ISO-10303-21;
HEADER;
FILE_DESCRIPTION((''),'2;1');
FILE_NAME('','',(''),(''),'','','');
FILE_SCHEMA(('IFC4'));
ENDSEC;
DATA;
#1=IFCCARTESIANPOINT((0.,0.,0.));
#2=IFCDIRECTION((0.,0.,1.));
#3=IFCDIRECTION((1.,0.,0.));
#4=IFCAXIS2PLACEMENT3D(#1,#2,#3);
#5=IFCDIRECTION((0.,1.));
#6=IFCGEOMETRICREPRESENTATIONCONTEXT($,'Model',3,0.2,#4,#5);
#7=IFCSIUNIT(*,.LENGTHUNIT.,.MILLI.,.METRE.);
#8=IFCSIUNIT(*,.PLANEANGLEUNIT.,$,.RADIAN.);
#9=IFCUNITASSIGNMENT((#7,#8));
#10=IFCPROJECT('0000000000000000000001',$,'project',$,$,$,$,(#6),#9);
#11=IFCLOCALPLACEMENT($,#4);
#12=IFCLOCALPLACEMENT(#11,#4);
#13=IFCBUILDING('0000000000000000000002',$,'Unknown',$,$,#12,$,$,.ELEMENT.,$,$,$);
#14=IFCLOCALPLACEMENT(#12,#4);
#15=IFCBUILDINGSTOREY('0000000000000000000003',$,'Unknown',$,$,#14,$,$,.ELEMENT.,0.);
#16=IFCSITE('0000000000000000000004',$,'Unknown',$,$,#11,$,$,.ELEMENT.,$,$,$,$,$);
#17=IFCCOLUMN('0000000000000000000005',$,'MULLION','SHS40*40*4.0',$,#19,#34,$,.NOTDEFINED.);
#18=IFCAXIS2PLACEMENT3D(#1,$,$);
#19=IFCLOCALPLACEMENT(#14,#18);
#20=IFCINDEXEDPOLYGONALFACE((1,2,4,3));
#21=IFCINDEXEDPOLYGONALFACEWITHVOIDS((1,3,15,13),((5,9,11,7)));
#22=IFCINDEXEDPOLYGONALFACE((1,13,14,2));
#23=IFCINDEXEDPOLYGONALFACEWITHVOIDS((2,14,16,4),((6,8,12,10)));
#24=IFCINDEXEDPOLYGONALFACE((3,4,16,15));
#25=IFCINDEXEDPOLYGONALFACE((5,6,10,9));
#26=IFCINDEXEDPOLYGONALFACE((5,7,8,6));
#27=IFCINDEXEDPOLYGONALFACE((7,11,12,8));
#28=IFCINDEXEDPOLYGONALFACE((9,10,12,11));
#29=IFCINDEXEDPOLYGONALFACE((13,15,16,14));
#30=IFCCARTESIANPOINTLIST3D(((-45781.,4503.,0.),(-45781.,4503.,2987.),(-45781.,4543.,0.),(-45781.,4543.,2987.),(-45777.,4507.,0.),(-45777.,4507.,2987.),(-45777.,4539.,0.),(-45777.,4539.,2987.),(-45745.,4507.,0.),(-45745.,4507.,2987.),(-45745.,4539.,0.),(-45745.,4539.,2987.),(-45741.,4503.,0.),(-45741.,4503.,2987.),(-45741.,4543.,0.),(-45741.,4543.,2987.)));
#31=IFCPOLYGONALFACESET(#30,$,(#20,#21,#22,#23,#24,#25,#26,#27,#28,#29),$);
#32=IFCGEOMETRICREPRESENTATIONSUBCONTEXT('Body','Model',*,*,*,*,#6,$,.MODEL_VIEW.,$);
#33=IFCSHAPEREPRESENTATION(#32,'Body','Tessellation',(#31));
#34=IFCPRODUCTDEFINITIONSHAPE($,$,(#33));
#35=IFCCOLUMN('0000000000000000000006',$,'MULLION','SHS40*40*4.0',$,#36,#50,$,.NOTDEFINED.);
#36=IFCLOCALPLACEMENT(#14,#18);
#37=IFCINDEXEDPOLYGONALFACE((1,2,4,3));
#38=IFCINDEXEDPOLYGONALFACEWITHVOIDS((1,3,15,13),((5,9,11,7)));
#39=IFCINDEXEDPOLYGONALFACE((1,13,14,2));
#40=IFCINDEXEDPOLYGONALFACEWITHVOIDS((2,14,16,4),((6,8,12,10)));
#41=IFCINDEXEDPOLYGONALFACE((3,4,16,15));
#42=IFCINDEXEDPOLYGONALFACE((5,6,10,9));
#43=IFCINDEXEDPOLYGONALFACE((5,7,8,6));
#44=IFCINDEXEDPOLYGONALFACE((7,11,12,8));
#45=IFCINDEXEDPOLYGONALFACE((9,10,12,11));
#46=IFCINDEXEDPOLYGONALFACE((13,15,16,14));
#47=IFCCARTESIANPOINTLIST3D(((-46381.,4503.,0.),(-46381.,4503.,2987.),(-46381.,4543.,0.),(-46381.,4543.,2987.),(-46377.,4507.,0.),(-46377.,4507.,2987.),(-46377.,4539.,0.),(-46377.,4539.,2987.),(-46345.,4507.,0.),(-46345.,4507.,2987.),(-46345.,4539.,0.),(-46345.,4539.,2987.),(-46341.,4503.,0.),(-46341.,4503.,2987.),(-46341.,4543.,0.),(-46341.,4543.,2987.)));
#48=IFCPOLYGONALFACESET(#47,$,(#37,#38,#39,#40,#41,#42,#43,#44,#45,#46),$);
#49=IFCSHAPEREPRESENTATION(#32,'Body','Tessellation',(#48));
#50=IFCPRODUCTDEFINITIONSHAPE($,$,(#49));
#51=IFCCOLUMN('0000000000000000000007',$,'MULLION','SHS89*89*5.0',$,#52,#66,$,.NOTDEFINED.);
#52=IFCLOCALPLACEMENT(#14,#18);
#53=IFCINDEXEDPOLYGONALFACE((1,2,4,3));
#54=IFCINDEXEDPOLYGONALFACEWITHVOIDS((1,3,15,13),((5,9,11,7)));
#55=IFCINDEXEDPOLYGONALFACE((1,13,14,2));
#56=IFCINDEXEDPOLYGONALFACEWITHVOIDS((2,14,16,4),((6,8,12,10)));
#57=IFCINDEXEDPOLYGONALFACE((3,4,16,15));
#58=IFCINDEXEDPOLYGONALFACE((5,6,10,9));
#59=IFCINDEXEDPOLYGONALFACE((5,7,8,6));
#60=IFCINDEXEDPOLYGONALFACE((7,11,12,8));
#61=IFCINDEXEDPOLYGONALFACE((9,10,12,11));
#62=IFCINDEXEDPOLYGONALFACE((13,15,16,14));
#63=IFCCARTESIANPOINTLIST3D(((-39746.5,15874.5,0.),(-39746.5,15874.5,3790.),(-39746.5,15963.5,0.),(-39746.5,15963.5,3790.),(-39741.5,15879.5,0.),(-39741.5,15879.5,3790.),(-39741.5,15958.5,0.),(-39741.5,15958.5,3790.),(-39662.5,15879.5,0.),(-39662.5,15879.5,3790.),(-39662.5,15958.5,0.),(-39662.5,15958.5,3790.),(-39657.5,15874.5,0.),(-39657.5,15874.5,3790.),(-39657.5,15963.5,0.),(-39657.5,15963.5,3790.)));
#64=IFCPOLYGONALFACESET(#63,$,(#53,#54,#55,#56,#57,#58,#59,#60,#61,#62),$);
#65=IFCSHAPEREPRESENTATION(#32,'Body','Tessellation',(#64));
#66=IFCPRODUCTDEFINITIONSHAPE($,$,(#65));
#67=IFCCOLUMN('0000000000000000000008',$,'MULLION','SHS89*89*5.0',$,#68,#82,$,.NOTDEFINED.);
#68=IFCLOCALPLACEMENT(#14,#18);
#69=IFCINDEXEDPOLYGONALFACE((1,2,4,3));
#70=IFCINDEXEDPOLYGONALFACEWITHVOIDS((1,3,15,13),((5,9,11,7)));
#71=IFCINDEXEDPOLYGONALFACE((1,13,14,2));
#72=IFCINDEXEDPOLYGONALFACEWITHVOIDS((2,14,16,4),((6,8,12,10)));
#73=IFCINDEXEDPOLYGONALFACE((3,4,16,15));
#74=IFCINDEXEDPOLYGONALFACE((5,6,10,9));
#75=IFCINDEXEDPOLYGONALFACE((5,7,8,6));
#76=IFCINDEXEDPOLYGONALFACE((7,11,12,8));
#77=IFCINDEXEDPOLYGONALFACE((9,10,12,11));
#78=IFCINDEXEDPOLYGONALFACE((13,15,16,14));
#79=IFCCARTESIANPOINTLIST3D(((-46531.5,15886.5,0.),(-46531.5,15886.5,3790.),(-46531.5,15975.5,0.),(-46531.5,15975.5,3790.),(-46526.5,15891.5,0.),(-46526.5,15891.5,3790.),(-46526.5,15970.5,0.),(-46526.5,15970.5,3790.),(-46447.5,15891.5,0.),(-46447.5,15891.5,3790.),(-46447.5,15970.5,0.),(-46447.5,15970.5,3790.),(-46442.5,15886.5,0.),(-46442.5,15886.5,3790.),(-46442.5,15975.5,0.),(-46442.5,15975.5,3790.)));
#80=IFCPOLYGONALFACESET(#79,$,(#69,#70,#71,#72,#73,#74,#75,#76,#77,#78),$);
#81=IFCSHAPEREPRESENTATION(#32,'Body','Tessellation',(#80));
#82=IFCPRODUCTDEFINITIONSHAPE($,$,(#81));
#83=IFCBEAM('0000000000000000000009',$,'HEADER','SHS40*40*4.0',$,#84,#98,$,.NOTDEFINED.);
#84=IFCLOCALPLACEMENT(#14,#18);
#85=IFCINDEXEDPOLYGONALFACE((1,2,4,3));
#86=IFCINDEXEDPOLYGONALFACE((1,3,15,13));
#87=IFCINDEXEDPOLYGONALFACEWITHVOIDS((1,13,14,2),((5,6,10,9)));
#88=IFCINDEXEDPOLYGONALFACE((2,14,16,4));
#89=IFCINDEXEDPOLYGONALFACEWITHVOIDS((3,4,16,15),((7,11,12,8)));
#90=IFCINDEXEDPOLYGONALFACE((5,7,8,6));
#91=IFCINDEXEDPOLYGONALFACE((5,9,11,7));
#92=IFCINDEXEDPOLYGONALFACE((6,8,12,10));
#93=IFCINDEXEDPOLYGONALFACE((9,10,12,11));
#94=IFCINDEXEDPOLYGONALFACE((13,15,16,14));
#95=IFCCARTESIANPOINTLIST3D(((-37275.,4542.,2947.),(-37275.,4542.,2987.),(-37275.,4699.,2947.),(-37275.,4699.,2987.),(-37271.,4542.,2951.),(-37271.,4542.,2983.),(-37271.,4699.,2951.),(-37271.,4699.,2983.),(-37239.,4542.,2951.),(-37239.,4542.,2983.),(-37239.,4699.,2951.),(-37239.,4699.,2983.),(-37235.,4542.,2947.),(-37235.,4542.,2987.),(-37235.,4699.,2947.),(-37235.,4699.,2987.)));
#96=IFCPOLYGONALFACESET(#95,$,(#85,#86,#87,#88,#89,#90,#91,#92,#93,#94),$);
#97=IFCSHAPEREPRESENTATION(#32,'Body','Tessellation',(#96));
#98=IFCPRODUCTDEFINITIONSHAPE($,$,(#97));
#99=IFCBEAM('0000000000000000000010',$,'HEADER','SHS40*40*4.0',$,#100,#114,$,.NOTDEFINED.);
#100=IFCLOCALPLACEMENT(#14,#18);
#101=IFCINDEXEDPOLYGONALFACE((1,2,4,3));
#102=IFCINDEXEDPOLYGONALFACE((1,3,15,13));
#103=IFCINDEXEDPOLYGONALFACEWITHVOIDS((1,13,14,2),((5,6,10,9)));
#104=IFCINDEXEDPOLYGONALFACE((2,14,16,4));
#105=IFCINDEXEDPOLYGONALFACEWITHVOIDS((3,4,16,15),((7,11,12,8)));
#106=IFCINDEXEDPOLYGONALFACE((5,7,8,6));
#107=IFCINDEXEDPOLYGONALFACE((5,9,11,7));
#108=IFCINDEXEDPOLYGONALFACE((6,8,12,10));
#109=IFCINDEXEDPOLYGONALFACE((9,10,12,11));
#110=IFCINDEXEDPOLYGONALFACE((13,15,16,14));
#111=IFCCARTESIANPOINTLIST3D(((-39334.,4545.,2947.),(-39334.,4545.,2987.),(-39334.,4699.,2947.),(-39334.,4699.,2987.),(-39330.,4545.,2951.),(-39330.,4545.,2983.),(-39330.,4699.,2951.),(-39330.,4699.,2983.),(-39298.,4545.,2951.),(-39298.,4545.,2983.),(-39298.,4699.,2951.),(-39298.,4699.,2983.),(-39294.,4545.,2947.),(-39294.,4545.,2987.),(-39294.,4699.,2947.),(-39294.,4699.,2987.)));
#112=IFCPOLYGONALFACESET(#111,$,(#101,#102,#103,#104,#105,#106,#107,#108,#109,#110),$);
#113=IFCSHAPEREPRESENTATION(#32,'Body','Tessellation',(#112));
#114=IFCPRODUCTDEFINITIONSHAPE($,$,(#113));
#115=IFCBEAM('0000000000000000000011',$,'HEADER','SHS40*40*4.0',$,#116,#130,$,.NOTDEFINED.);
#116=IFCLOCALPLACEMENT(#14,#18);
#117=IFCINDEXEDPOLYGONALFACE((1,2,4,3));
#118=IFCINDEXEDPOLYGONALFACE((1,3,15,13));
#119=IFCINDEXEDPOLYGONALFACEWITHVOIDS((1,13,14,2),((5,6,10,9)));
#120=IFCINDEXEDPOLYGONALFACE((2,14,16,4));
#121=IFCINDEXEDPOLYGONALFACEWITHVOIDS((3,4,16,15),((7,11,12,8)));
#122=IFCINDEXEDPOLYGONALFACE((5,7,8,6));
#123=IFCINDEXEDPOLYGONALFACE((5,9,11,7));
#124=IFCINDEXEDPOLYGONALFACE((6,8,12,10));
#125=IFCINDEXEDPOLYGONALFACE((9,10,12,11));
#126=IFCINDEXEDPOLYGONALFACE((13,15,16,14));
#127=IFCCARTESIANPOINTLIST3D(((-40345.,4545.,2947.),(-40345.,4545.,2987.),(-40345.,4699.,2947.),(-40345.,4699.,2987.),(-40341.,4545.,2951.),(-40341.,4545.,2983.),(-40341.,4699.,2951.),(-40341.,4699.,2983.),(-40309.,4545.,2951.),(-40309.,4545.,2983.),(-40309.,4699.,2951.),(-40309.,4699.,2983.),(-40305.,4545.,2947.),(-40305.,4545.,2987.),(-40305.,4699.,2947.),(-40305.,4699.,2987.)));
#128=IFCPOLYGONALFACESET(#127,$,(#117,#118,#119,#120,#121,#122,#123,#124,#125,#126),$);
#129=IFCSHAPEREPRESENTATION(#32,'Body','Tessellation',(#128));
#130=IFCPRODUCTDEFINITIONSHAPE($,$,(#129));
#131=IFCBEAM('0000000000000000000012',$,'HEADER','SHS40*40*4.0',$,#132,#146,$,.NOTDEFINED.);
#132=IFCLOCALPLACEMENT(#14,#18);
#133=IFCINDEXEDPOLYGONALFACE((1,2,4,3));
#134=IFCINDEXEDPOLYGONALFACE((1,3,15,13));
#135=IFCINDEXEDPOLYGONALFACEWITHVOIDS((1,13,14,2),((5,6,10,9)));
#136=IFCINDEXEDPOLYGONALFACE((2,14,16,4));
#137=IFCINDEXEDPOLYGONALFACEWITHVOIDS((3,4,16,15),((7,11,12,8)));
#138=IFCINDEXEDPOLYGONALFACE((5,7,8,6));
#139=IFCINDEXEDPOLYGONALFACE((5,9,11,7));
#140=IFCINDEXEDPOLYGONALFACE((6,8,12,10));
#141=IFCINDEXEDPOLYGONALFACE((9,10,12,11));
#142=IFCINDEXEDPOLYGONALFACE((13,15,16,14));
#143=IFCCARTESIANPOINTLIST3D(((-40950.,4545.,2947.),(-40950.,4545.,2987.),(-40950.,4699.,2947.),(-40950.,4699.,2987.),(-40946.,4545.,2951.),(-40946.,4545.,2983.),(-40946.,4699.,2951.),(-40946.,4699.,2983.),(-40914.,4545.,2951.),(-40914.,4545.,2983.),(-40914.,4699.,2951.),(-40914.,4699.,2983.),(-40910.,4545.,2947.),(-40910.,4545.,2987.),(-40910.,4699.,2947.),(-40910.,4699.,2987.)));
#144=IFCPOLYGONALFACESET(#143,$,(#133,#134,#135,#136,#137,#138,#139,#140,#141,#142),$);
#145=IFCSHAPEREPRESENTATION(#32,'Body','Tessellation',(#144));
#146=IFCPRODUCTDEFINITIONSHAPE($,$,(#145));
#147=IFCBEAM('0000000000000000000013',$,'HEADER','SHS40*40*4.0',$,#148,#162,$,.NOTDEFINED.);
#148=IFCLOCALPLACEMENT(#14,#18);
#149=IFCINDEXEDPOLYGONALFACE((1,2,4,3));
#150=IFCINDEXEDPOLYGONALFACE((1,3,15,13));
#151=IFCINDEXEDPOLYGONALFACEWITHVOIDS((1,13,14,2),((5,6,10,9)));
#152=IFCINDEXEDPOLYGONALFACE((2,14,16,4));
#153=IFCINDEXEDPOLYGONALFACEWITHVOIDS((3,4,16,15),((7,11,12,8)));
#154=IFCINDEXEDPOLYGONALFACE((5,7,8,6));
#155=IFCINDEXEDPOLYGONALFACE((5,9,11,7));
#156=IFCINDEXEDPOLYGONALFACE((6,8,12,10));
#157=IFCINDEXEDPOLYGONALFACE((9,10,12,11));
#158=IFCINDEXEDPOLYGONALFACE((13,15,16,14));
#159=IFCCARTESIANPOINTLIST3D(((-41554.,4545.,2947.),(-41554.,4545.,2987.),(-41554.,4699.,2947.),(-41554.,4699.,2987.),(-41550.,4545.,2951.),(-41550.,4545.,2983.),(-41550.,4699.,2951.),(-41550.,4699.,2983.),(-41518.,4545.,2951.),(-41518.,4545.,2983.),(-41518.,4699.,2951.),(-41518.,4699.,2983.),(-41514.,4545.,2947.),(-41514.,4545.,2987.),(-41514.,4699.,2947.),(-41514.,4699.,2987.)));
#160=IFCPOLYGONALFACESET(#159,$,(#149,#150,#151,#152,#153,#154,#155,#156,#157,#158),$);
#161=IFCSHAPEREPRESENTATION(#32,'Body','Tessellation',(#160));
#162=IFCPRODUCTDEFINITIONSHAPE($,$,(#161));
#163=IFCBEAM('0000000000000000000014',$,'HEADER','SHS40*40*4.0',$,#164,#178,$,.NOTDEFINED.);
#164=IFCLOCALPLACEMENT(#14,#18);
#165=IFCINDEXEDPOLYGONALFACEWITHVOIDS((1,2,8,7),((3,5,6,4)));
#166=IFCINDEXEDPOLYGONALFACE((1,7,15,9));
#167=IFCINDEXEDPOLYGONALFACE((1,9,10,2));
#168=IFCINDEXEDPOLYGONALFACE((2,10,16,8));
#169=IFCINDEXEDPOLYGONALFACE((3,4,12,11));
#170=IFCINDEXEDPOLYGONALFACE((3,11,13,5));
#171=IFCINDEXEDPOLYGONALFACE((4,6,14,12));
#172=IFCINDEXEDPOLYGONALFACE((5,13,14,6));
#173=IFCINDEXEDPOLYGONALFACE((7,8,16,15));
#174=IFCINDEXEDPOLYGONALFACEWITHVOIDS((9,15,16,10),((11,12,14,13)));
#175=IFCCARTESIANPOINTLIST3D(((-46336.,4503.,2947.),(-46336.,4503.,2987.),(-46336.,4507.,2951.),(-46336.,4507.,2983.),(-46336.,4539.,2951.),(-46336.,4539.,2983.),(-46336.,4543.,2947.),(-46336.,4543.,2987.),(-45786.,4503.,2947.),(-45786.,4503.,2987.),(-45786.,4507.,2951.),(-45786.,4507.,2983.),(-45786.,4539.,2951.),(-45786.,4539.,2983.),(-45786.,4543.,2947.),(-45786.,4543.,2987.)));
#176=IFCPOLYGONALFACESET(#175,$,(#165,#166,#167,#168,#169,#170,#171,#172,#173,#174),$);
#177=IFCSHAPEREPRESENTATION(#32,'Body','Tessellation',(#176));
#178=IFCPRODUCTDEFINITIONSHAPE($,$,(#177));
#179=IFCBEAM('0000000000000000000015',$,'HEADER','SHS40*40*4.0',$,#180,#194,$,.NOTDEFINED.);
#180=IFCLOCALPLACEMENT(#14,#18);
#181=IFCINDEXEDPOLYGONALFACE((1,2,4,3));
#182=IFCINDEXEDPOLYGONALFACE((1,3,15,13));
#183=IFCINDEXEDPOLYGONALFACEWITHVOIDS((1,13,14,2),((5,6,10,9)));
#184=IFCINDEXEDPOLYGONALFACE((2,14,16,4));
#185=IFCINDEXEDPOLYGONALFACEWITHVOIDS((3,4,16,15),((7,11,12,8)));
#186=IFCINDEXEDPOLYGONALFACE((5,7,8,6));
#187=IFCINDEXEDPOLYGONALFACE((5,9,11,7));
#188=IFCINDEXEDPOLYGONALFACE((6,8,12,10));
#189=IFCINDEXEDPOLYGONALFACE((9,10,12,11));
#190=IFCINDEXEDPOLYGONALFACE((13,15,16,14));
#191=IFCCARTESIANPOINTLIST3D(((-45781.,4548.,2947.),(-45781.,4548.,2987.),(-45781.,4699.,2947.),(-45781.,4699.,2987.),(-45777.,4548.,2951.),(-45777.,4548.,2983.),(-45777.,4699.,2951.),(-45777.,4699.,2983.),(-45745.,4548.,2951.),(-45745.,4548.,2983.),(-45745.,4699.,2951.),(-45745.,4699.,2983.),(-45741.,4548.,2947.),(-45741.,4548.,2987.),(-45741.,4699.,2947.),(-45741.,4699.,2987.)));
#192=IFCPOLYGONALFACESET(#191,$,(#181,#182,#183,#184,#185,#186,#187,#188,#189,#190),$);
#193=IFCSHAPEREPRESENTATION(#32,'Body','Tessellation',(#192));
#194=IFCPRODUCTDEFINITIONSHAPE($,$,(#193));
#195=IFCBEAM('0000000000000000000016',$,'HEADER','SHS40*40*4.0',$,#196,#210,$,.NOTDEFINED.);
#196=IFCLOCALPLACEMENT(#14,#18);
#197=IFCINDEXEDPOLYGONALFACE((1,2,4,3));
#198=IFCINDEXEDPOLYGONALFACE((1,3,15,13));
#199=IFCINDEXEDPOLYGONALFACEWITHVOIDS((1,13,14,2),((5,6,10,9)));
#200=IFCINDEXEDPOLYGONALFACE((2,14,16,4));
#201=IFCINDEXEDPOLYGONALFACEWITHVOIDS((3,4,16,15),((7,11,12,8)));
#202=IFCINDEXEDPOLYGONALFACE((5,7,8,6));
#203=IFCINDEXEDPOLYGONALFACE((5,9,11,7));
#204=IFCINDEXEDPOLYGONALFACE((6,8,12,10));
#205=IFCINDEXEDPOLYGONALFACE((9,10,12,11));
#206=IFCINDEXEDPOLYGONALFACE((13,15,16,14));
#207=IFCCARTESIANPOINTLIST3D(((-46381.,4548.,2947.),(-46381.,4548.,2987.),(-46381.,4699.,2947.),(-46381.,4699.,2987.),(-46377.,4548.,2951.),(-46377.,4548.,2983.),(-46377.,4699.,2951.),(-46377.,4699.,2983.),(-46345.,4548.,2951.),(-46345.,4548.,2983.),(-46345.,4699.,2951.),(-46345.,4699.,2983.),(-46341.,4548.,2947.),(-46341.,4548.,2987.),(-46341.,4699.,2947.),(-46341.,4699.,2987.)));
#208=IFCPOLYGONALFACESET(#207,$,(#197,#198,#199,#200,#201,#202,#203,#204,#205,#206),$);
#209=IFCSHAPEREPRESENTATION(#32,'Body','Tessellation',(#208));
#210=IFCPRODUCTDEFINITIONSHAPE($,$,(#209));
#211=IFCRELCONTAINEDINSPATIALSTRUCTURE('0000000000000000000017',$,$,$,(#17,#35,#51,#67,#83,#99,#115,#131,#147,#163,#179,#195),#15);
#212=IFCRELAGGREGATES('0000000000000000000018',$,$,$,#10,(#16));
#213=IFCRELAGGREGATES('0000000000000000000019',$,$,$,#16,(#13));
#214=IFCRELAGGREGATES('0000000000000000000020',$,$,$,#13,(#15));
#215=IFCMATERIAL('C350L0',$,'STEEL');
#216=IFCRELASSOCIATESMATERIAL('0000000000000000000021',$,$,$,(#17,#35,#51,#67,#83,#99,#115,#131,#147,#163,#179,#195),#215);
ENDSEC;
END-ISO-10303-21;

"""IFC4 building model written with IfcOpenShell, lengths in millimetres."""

from ifc_helpers import new_model, si_unit, direction, frame, origin_with_axes, place, context, subcontext, project, spatial, line, indexed_curve, outline, extrude, material, element, save


model = new_model("IFC4")

# Units and contexts
model_context = context("Model", 3, precision=0.2, world=origin_with_axes(), true_north=direction((0.0, 1.0)))
body_context = subcontext(model_context, "Body", "Model", "MODEL_VIEW")
ifc_project = project(units=[si_unit("LENGTHUNIT", "METRE", prefix="MILLI"), si_unit("PLANEANGLEUNIT", "RADIAN")], contexts=[model_context])

# Site, building, storey
site_placement = place(None, origin_with_axes())
site = spatial("IfcSite", under=ifc_project, at=site_placement, Name="Unknown", CompositionType="ELEMENT")
building_placement = place(site_placement, origin_with_axes())
building = spatial("IfcBuilding", under=site, at=building_placement, Name="Unknown", CompositionType="ELEMENT")
storey_placement = place(building_placement, origin_with_axes())
storey = spatial("IfcBuildingStorey", under=building, at=storey_placement, Name="Unknown", CompositionType="ELEMENT", Elevation=0.0)

# Columns
ifc_material_1 = material(Name="C350L0", Category="STEEL")
for number, where, z_axis, x_axis, name in (
    (1, (-45761.0, 4523.0, 0.0), (0.000017, -1.0, 0.0), (0.0, 0.0, 1.0), "MULLION"),
    (2, (-46361.0, 4523.0, 0.0), (0.000017, -1.0, 0.0), (0.0, 0.0, 1.0), "MULLION"),
):
    element("IfcColumn", number, at=place(storey_placement, frame(where, z_axis=z_axis, x_axis=x_axis)), inside=storey, material=ifc_material_1, Name=name, Description="SHS40*40*4.0", PredefinedType="NOTDEFINED", context=body_context, shape_type="SolidModel", body=[
        extrude(outline(indexed_curve([(-20.0, -20.0), (20.0, -20.0), (20.0, 20.0), (-20.0, 20.0)], segments=[line(1, 2, 3, 4, 1)]), holes=[indexed_curve([(-16.0, -16.0), (-16.0, 16.0), (16.0, 16.0), (16.0, -16.0)], segments=[line(1, 2, 3, 4, 1)])]), frame((0.0, 0.0, 0.0), z_axis=(-1.0, 0.0, 0.0), x_axis=(0.0, 0.0, 1.0)), (0.0, 0.0, -1.0), 2987.0),
    ])
for number, where, z_axis, x_axis, name in (
    (3, (-39702.0, 15919.0, 0.0), (0.000017, -1.0, 0.0), (0.0, 0.0, 1.0), "MULLION"),
    (4, (-46487.0, 15931.0, 0.0), (0.000017, -1.0, 0.0), (0.0, 0.0, 1.0), "MULLION"),
):
    element("IfcColumn", number, at=place(storey_placement, frame(where, z_axis=z_axis, x_axis=x_axis)), inside=storey, material=ifc_material_1, Name=name, Description="SHS89*89*5.0", PredefinedType="NOTDEFINED", context=body_context, shape_type="SolidModel", body=[
        extrude(outline(indexed_curve([(-44.5, -44.5), (44.5, -44.5), (44.5, 44.5), (-44.5, 44.5)], segments=[line(1, 2, 3, 4, 1)]), holes=[indexed_curve([(-39.5, -39.5), (-39.5, 39.5), (39.5, 39.5), (39.5, -39.5)], segments=[line(1, 2, 3, 4, 1)])]), frame((0.0, 0.0, 0.0), z_axis=(-1.0, 0.0, 0.0), x_axis=(0.0, 0.0, 1.0)), (0.0, 0.0, -1.0), 3790.0),
    ])

# Beams
beam_1_placement = place(storey_placement, frame((-37255.0, 4542.0, 2967.0), z_axis=(0.0, 0.0, 1.0), x_axis=(0.0, 1.0, 0.0)))
element("IfcBeam", 5, at=beam_1_placement, inside=storey, material=ifc_material_1, Name="HEADER", Description="SHS40*40*4.0", PredefinedType="NOTDEFINED", context=body_context, shape_type="SolidModel", body=[
    extrude(outline(indexed_curve([(-20.0, -20.0), (20.0, -20.0), (20.0, 20.0), (-20.0, 20.0)], segments=[line(1, 2, 3, 4, 1)]), holes=[indexed_curve([(-16.0, -16.0), (-16.0, 16.0), (16.0, 16.0), (16.0, -16.0)], segments=[line(1, 2, 3, 4, 1)])]), frame((0.0, 0.0, 0.0), z_axis=(-1.0, 0.0, 0.0), x_axis=(0.0, 0.0, 1.0)), (0.0, 0.0, -1.0), 157.0),
])
for number, where, z_axis, x_axis, name in (
    (6, (-39314.0, 4545.0, 2967.0), (0.0, 0.0, 1.0), (0.0, 1.0, 0.0), "HEADER"),
    (7, (-40325.0, 4545.0, 2967.0), (0.0, 0.0, 1.0), (0.0, 1.0, 0.0), "HEADER"),
    (8, (-40930.0, 4545.0, 2967.0), (0.0, 0.0, 1.0), (0.0, 1.0, 0.0), "HEADER"),
    (9, (-41534.0, 4545.0, 2967.0), (0.0, 0.0, 1.0), (0.0, 1.0, 0.0), "HEADER"),
):
    element("IfcBeam", number, at=place(storey_placement, frame(where, z_axis=z_axis, x_axis=x_axis)), inside=storey, material=ifc_material_1, Name=name, Description="SHS40*40*4.0", PredefinedType="NOTDEFINED", context=body_context, shape_type="SolidModel", body=[
        extrude(outline(indexed_curve([(-20.0, -20.0), (20.0, -20.0), (20.0, 20.0), (-20.0, 20.0)], segments=[line(1, 2, 3, 4, 1)]), holes=[indexed_curve([(-16.0, -16.0), (-16.0, 16.0), (16.0, 16.0), (16.0, -16.0)], segments=[line(1, 2, 3, 4, 1)])]), frame((0.0, 0.0, 0.0), z_axis=(-1.0, 0.0, 0.0), x_axis=(0.0, 0.0, 1.0)), (0.0, 0.0, -1.0), 154.0),
    ])
beam_2_placement = place(storey_placement, frame((-46336.0, 4523.0, 2967.0), z_axis=(0.0, 0.0, 1.0), x_axis=(1.0, 0.0, 0.0)))
element("IfcBeam", 10, at=beam_2_placement, inside=storey, material=ifc_material_1, Name="HEADER", Description="SHS40*40*4.0", PredefinedType="NOTDEFINED", context=body_context, shape_type="SolidModel", body=[
    extrude(outline(indexed_curve([(-20.0, -20.0), (20.0, -20.0), (20.0, 20.0), (-20.0, 20.0)], segments=[line(1, 2, 3, 4, 1)]), holes=[indexed_curve([(-16.0, -16.0), (-16.0, 16.0), (16.0, 16.0), (16.0, -16.0)], segments=[line(1, 2, 3, 4, 1)])]), frame((0.0, 0.0, 0.0), z_axis=(-1.0, 0.0, 0.0), x_axis=(0.0, 0.0, 1.0)), (0.0, 0.0, -1.0), 550.0),
])
for number, where, z_axis, x_axis, name in (
    (11, (-45761.0, 4548.0, 2967.0), (0.0, 0.0, 1.0), (0.0, 1.0, 0.0), "HEADER"),
    (12, (-46361.0, 4548.0, 2967.0), (0.0, 0.0, 1.0), (0.0, 1.0, 0.0), "HEADER"),
):
    element("IfcBeam", number, at=place(storey_placement, frame(where, z_axis=z_axis, x_axis=x_axis)), inside=storey, material=ifc_material_1, Name=name, Description="SHS40*40*4.0", PredefinedType="NOTDEFINED", context=body_context, shape_type="SolidModel", body=[
        extrude(outline(indexed_curve([(-20.0, -20.0), (20.0, -20.0), (20.0, 20.0), (-20.0, 20.0)], segments=[line(1, 2, 3, 4, 1)]), holes=[indexed_curve([(-16.0, -16.0), (-16.0, 16.0), (16.0, 16.0), (16.0, -16.0)], segments=[line(1, 2, 3, 4, 1)])]), frame((0.0, 0.0, 0.0), z_axis=(-1.0, 0.0, 0.0), x_axis=(0.0, 0.0, 1.0)), (0.0, 0.0, -1.0), 151.0),
    ])

save(model, "model.ifc")
